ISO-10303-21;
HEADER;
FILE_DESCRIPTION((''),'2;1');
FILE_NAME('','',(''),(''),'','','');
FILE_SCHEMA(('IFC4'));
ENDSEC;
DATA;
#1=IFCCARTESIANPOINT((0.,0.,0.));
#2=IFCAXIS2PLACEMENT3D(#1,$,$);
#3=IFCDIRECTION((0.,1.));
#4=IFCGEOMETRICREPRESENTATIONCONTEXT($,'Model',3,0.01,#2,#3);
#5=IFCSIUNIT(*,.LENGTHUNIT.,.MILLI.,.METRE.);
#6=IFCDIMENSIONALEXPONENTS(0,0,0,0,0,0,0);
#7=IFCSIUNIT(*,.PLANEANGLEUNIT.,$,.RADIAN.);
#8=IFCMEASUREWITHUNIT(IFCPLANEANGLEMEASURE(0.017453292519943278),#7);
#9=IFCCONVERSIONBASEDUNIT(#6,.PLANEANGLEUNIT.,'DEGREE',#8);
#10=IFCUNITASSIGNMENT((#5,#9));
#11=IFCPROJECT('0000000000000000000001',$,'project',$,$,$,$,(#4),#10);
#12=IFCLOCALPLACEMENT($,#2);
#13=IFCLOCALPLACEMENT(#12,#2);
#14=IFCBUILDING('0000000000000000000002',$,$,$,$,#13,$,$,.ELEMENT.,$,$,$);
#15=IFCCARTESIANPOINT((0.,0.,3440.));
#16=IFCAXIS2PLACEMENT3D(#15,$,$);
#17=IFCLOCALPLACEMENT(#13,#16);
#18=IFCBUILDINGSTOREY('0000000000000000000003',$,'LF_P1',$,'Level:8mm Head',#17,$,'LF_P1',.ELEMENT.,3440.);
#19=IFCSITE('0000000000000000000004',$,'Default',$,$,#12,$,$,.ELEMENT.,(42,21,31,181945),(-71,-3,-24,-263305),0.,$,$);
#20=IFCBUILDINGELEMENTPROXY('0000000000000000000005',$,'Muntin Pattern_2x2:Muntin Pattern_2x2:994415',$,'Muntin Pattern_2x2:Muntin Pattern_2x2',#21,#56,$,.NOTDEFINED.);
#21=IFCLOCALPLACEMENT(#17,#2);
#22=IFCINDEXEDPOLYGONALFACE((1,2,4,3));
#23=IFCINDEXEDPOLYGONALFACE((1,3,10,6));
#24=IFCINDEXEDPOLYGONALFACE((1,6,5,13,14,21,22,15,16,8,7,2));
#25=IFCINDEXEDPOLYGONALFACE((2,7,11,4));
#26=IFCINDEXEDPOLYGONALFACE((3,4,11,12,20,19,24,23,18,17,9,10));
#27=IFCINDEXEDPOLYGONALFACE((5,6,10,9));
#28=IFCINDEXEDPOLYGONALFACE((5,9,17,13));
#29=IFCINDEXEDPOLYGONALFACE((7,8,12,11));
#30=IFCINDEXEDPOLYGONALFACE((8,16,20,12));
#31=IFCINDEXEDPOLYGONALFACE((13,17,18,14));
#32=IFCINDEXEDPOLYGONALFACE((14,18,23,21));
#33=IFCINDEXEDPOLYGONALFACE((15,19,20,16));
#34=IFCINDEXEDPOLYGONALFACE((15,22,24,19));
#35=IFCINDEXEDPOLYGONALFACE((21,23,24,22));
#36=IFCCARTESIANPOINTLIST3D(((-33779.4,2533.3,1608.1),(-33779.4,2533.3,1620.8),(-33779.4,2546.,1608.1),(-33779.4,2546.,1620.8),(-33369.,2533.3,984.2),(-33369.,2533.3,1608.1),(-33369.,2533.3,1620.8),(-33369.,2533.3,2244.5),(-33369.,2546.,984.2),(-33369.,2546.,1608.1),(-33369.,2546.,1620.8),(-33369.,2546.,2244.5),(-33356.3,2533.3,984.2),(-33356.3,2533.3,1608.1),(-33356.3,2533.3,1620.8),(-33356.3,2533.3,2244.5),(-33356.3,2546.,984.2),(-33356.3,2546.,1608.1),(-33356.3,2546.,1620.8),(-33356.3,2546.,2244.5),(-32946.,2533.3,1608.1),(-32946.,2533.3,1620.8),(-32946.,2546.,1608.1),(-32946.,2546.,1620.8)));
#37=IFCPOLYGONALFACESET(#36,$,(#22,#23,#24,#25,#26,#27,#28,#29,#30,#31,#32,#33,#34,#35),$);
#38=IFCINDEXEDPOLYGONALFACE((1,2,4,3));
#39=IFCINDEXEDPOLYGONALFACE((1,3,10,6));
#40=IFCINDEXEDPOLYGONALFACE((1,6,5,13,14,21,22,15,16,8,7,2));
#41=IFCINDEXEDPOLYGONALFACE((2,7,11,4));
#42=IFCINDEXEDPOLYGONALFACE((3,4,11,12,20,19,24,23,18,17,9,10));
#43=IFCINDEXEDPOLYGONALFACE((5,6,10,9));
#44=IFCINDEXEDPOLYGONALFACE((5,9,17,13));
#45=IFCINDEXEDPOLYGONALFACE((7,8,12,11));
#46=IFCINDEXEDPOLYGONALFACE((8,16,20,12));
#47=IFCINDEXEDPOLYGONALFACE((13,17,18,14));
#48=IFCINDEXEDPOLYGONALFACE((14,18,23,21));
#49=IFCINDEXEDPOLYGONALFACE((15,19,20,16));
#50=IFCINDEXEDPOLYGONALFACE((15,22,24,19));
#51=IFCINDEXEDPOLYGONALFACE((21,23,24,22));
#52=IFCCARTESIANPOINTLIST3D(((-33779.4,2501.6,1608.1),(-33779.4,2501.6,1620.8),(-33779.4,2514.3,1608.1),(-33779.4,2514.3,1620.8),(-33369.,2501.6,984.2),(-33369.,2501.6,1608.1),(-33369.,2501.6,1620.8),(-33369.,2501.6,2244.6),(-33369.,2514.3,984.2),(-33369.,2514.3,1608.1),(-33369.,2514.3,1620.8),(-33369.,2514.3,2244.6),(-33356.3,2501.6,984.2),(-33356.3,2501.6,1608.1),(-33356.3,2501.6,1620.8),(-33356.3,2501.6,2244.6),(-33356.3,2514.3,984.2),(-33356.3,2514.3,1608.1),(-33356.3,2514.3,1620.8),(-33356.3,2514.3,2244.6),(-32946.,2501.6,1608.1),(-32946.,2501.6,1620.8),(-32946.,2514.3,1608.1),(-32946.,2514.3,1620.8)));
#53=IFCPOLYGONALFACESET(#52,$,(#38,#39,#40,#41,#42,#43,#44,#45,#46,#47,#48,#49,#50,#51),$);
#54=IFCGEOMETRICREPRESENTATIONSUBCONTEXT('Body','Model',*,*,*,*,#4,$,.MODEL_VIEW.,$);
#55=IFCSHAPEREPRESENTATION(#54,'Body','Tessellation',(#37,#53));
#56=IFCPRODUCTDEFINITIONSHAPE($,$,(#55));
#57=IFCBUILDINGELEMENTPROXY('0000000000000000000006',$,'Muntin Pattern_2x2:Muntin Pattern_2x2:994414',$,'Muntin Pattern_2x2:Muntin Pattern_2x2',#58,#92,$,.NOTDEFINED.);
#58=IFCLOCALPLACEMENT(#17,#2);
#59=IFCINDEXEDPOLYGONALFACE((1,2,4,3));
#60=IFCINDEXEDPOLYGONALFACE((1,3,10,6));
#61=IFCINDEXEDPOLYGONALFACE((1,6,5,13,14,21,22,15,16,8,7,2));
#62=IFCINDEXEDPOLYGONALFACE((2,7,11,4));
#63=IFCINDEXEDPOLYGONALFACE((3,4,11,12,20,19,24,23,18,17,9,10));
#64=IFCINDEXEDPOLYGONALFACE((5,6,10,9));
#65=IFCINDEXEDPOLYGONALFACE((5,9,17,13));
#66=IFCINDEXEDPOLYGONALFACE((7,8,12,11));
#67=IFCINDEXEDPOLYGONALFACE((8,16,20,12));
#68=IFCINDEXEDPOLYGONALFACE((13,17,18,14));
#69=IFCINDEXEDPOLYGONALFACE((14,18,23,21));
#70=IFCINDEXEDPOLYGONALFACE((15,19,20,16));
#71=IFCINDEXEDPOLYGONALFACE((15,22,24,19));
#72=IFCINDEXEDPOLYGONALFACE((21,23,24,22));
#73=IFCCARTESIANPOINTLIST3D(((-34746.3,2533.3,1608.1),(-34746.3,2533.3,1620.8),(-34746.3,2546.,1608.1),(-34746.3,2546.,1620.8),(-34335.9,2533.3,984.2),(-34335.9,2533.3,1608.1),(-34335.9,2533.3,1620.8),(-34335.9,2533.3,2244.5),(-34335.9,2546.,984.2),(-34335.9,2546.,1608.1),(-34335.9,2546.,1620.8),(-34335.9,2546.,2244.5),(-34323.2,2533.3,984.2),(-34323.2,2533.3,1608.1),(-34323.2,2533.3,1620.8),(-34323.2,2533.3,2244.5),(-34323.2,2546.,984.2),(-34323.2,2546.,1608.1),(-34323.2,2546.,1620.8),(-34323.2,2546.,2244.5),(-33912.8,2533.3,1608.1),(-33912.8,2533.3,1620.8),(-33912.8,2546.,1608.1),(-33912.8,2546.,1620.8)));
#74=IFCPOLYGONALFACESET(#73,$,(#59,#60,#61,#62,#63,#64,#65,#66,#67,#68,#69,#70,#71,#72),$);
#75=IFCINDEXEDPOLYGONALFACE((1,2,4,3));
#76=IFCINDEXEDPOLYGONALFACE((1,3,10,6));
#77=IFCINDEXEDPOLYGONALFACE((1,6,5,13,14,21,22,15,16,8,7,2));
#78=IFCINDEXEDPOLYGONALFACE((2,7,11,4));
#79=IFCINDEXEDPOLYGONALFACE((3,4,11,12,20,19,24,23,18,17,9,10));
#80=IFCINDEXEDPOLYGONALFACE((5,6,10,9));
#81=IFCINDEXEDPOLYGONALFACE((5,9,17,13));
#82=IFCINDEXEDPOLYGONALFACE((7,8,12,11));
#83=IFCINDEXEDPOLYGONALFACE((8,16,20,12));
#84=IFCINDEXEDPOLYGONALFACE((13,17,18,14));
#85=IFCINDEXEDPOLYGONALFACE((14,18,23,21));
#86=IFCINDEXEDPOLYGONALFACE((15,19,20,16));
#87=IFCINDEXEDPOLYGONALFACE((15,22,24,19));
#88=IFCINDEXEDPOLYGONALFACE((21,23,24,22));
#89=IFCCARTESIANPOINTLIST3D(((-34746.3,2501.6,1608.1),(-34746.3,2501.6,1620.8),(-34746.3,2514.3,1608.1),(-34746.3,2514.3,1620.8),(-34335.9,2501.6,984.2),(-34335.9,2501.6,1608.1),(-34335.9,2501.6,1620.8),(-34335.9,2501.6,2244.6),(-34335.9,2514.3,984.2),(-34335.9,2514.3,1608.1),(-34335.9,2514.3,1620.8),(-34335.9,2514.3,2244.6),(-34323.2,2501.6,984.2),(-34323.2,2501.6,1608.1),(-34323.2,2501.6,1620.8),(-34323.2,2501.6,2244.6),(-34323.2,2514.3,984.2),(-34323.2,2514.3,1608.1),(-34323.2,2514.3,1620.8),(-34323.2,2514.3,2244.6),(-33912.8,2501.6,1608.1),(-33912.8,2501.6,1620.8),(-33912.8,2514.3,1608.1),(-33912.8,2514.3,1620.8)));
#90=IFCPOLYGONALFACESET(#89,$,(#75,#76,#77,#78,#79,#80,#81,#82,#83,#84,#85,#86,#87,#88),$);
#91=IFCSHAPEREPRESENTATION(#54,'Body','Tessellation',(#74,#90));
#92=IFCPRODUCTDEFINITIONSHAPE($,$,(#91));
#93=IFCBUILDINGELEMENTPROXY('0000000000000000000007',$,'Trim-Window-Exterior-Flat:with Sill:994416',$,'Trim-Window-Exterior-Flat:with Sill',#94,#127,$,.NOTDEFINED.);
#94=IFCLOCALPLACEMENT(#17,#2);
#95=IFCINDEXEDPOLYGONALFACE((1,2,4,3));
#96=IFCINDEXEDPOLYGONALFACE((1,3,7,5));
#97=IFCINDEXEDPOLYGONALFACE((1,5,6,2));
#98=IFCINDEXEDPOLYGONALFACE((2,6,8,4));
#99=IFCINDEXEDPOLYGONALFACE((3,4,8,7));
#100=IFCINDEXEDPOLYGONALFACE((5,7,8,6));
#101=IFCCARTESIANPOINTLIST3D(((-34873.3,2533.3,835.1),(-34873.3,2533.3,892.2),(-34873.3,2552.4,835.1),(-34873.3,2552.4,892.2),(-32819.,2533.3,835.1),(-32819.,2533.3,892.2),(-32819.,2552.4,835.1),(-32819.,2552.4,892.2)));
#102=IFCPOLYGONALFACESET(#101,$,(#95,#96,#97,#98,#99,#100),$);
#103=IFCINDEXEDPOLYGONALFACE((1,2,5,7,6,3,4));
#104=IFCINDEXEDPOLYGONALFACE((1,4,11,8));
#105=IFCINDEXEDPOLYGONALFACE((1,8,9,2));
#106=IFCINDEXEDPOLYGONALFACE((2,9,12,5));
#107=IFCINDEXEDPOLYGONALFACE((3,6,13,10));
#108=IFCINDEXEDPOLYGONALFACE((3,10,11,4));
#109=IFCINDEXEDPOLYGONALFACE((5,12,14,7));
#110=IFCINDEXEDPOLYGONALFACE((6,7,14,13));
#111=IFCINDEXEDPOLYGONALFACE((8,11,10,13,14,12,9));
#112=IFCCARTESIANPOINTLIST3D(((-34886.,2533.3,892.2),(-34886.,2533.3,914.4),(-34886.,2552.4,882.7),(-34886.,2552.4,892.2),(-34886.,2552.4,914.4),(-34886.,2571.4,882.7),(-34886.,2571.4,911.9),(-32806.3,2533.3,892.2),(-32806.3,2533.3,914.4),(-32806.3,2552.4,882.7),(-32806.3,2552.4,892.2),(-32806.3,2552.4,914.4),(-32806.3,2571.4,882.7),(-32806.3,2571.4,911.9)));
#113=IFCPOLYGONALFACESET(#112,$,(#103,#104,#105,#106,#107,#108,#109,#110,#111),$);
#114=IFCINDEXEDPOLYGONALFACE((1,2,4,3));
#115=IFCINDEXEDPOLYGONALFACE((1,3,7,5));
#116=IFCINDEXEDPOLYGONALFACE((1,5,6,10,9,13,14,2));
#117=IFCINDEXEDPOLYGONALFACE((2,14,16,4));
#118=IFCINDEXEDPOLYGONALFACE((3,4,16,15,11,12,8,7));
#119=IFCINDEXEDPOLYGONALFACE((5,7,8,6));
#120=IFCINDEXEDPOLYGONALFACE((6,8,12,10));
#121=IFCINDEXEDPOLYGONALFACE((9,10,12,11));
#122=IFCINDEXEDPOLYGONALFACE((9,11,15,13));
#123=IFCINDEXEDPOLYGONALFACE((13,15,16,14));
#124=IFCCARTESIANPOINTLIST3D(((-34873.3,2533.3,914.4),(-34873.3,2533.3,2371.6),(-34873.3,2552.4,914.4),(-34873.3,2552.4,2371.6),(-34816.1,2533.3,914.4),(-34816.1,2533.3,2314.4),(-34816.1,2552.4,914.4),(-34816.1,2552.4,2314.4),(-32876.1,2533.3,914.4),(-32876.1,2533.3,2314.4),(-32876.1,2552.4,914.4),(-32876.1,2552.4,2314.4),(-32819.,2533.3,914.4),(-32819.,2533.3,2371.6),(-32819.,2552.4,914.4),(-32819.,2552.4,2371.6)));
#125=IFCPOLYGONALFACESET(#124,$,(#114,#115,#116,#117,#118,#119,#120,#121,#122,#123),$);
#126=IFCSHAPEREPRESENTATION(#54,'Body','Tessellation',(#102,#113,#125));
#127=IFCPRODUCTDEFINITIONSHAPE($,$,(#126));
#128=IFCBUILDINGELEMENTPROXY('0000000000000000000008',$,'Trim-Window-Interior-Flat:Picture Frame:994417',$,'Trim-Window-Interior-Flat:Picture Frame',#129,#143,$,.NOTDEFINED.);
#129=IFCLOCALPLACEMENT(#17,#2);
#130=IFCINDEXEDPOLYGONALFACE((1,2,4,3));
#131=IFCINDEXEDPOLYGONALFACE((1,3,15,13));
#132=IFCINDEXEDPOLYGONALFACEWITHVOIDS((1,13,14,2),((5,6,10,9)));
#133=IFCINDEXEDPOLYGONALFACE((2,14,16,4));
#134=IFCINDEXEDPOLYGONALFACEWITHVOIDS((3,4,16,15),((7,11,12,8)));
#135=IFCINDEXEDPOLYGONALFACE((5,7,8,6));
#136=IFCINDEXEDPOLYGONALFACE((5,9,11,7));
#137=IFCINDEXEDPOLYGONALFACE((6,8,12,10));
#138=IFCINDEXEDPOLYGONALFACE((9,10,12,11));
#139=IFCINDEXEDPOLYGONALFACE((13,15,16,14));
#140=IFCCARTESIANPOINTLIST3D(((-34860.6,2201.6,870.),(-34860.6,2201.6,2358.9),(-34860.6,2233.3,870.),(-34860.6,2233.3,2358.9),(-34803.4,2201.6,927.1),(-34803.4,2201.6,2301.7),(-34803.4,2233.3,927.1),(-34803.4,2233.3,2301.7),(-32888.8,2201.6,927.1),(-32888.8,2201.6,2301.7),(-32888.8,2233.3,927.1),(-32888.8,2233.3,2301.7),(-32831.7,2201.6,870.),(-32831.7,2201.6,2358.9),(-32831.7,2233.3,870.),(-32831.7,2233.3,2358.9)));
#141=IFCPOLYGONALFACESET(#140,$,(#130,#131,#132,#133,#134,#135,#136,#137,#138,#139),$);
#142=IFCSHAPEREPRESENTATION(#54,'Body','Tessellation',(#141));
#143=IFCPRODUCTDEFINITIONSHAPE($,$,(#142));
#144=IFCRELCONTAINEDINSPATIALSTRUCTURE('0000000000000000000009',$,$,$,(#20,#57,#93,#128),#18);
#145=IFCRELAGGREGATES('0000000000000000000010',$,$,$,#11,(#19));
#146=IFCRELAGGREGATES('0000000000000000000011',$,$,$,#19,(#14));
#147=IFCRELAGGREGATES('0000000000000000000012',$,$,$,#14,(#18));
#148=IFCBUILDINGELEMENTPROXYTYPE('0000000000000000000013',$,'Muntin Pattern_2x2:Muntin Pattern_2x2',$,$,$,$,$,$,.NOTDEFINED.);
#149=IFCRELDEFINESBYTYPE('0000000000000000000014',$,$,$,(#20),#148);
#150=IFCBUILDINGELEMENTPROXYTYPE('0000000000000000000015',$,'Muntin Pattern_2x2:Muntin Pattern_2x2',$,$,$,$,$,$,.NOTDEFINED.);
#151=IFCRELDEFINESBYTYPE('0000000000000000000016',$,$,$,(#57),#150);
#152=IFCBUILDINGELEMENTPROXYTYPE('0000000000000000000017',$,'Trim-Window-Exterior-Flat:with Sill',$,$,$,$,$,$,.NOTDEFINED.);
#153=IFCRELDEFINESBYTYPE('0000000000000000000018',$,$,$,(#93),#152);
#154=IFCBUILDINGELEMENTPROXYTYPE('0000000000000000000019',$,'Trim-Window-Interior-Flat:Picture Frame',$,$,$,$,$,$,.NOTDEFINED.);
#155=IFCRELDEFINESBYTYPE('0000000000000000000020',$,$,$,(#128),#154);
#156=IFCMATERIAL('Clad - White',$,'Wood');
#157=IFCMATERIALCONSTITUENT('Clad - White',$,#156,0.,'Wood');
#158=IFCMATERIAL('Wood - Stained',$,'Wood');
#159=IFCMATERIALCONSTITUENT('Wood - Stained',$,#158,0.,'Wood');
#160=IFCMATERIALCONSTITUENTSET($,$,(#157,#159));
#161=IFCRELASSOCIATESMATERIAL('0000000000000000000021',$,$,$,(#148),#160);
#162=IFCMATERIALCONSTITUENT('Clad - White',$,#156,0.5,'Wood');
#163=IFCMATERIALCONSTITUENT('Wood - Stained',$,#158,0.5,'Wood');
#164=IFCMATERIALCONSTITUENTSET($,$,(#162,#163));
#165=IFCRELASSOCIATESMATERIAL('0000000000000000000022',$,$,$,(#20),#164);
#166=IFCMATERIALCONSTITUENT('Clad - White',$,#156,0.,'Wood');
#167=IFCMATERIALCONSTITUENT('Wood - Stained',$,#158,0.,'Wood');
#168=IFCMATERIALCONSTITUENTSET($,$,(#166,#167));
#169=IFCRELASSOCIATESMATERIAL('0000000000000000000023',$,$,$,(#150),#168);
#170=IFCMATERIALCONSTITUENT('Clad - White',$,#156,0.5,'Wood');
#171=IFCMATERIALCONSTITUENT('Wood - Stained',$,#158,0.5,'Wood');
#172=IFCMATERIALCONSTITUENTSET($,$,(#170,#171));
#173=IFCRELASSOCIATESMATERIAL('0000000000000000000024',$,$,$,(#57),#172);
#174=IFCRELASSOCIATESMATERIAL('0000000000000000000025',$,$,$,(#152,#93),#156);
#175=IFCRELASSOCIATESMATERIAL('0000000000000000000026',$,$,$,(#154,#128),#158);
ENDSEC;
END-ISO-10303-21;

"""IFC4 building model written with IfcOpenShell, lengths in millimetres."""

from ifc_helpers import new_model, entity, si_unit, converted_unit, direction, frame, origin, place, context, subcontext, project, spatial, indexed_curve, outline, extrude, source, transform, mapped, material, constituent, constituent_set, type_object, type_shapes, element, save


model = new_model("IFC4")

# Units and contexts
model_context = context("Model", 3, precision=0.01, world=origin(), true_north=direction((0.0, 1.0)))
body_context = subcontext(model_context, "Body", "Model", "MODEL_VIEW")
ifc_project = project(units=[si_unit("LENGTHUNIT", "METRE", prefix="MILLI"), converted_unit("PLANEANGLEUNIT", "DEGREE", entity("IfcPlaneAngleMeasure", 0.017453292519943278), si_unit("PLANEANGLEUNIT", "RADIAN"), dimensions=[0, 0, 0, 0, 0, 0, 0])], contexts=[model_context])

# Site, building, storey
site_placement = place(None, origin())
site = spatial("IfcSite", under=ifc_project, at=site_placement, Name="Default", CompositionType="ELEMENT", RefLatitude=(42, 21, 31, 181945), RefLongitude=(-71, -3, -24, -263305), RefElevation=0.0)
building_placement = place(site_placement, origin())
building = spatial("IfcBuilding", under=site, at=building_placement, CompositionType="ELEMENT")
storey_placement = place(building_placement, frame((0.0, 0.0, 3440.0)))
storey = spatial("IfcBuildingStorey", under=building, at=storey_placement, Name="LF_P1", ObjectType="Level:8mm Head", LongName="LF_P1", CompositionType="ELEMENT", Elevation=3440.0)

# Building element proxies
ifc_material_1 = material(Name="Clad - White", Category="Wood")
ifc_material_2 = material(Name="Wood - Stained", Category="Wood")
ifc_constituent_1 = constituent(ifc_material_1, Name="Clad - White", Category="Wood", fraction=0.5)
ifc_constituent_2 = constituent(ifc_material_2, Name="Wood - Stained", Category="Wood", fraction=0.5)
ifc_constituent_set_1 = constituent_set(constituents=[ifc_constituent_1, ifc_constituent_2])
ifc_constituent_3 = constituent(ifc_material_1, Name="Clad - White", Category="Wood", fraction=0.0)
ifc_constituent_4 = constituent(ifc_material_2, Name="Wood - Stained", Category="Wood", fraction=0.0)
ifc_constituent_set_2 = constituent_set(constituents=[ifc_constituent_3, ifc_constituent_4])
building_element_proxy_type_1 = type_object("IfcBuildingElementProxyType", Name="Muntin Pattern_2x2:Muntin Pattern_2x2", PredefinedType="NOTDEFINED", material=ifc_constituent_set_2)
shared_shape_1 = source(origin(), body_context, "Body", "SweptSolid", [
    extrude(outline(indexed_curve([(6.4, -6.4), (630.1, -6.4), (630.1, 6.3), (6.4, 6.3), (6.4, 416.7), (-6.3, 416.7), (-6.3, 6.3), (-630.2, 6.3), (-630.2, -6.4), (-6.3, -6.4), (-6.3, -416.7), (6.4, -416.7), (6.4, -6.4)], self_intersect=False)), frame((0.0, -22.2, 630.1), z_axis=(0.0, 1.0, 0.0), x_axis=(0.0, 0.0, 1.0)), (0.0, 0.0, 1.0), 12.7),
    extrude(outline(indexed_curve([(6.4, -6.4), (630.2, -6.4), (630.2, 6.3), (6.4, 6.3), (6.4, 416.7), (-6.3, 416.7), (-6.3, 6.3), (-630.2, 6.3), (-630.2, -6.4), (-6.3, -6.4), (-6.3, -416.7), (6.4, -416.7), (6.4, -6.4)], self_intersect=False)), frame((0.0, 9.5, 630.2), z_axis=(0.0, 1.0, 0.0), x_axis=(0.0, 0.0, 1.0)), (0.0, 0.0, 1.0), 12.7),
])
type_shapes(building_element_proxy_type_1, [shared_shape_1])
proxy_1_placement = place(storey_placement, frame((-33362.7, 2523.8, 984.3), z_axis=(0.0, 0.0, 1.0), x_axis=(-1.0, 0.0, 0.0)))
element("IfcBuildingElementProxy", 1, at=proxy_1_placement, inside=storey, type_object=building_element_proxy_type_1, material=ifc_constituent_set_1, Name="Muntin Pattern_2x2:Muntin Pattern_2x2:994415", ObjectType="Muntin Pattern_2x2:Muntin Pattern_2x2", PredefinedType="NOTDEFINED", context=body_context, shape_type="MappedRepresentation", body=[
    mapped(shared_shape_1, transform((0.0, 0.0, 0.0), scale=1.0)),
])
ifc_constituent_5 = constituent(ifc_material_1, Name="Clad - White", Category="Wood", fraction=0.5)
ifc_constituent_6 = constituent(ifc_material_2, Name="Wood - Stained", Category="Wood", fraction=0.5)
ifc_constituent_set_3 = constituent_set(constituents=[ifc_constituent_5, ifc_constituent_6])
ifc_constituent_7 = constituent(ifc_material_1, Name="Clad - White", Category="Wood", fraction=0.0)
ifc_constituent_8 = constituent(ifc_material_2, Name="Wood - Stained", Category="Wood", fraction=0.0)
ifc_constituent_set_4 = constituent_set(constituents=[ifc_constituent_7, ifc_constituent_8])
building_element_proxy_type_2 = type_object("IfcBuildingElementProxyType", Name="Muntin Pattern_2x2:Muntin Pattern_2x2", PredefinedType="NOTDEFINED", material=ifc_constituent_set_4)
shared_shape_2 = source(origin(), body_context, "Body", "SweptSolid", [
    extrude(outline(indexed_curve([(6.4, -6.4), (630.1, -6.4), (630.1, 6.3), (6.4, 6.3), (6.4, 416.7), (-6.3, 416.7), (-6.3, 6.3), (-630.2, 6.3), (-630.2, -6.4), (-6.3, -6.4), (-6.3, -416.7), (6.4, -416.7), (6.4, -6.4)], self_intersect=False)), frame((0.0, 9.5, 630.1), z_axis=(0.0, 1.0, 0.0), x_axis=(0.0, 0.0, 1.0)), (0.0, 0.0, 1.0), 12.7),
    extrude(outline(indexed_curve([(6.4, -6.4), (630.2, -6.4), (630.2, 6.3), (6.4, 6.3), (6.4, 416.7), (-6.3, 416.7), (-6.3, 6.3), (-630.2, 6.3), (-630.2, -6.4), (-6.3, -6.4), (-6.3, -416.7), (6.4, -416.7), (6.4, -6.4)], self_intersect=False)), frame((0.0, -22.2, 630.2), z_axis=(0.0, 1.0, 0.0), x_axis=(0.0, 0.0, 1.0)), (0.0, 0.0, 1.0), 12.7),
])
type_shapes(building_element_proxy_type_2, [shared_shape_2])
proxy_2_placement = place(storey_placement, frame((-34329.5, 2523.8, 984.3)))
element("IfcBuildingElementProxy", 2, at=proxy_2_placement, inside=storey, type_object=building_element_proxy_type_2, material=ifc_constituent_set_3, Name="Muntin Pattern_2x2:Muntin Pattern_2x2:994414", ObjectType="Muntin Pattern_2x2:Muntin Pattern_2x2", PredefinedType="NOTDEFINED", context=body_context, shape_type="MappedRepresentation", body=[
    mapped(shared_shape_2, transform((0.0, 0.0, 0.0), scale=1.0)),
])
building_element_proxy_type_3 = type_object("IfcBuildingElementProxyType", Name="Trim-Window-Exterior-Flat:with Sill", PredefinedType="NOTDEFINED", material=ifc_material_1)
shared_shape_3 = source(origin(), body_context, "Body", "SweptSolid", [
    extrude(outline(indexed_curve([(-1027.1, -28.6), (1027.1, -28.6), (1027.1, 28.6), (-1027.1, 28.6), (-1027.1, -28.6)], self_intersect=False)), frame((0.0, -1450.8, 0.0), z_axis=(0.0, 0.0, 1.0), x_axis=(-1.0, 0.0, 0.0)), (0.0, 0.0, 1.0), 19.0),
    extrude(outline(indexed_curve([(-19.0, -16.0), (0.0, -16.0), (0.0, -6.4), (19.0, -6.4), (19.0, 15.8), (0.0, 15.8), (-19.0, 13.3), (-19.0, -16.0)], self_intersect=False)), frame((-1039.8, -1415.8, 19.0), z_axis=(1.0, 0.0, 0.0), x_axis=(0.0, 0.0, -1.0)), (0.0, 0.0, 1.0), 2079.7),
    extrude(outline(indexed_curve([(-742.9, -1027.1), (714.3, -1027.1), (714.3, -970.0), (-685.7, -970.0), (-685.7, 970.0), (714.3, 970.0), (714.3, 1027.1), (-742.9, 1027.1), (-742.9, -1027.1)], self_intersect=False)), frame((0.0, -685.7, 0.0), z_axis=(0.0, 0.0, 1.0), x_axis=(0.0, -1.0, 0.0)), (0.0, 0.0, 1.0), 19.0),
])
type_shapes(building_element_proxy_type_3, [shared_shape_3])
proxy_3_placement = place(storey_placement, frame((-33846.1, 2533.3, 2314.4), z_axis=(0.0, 1.0, 0.0), x_axis=(-1.0, 0.0, 0.0)))
element("IfcBuildingElementProxy", 3, at=proxy_3_placement, inside=storey, type_object=building_element_proxy_type_3, material=ifc_material_1, Name="Trim-Window-Exterior-Flat:with Sill:994416", ObjectType="Trim-Window-Exterior-Flat:with Sill", PredefinedType="NOTDEFINED", context=body_context, shape_type="MappedRepresentation", body=[
    mapped(shared_shape_3, transform((0.0, 0.0, 0.0), scale=1.0)),
])
building_element_proxy_type_4 = type_object("IfcBuildingElementProxyType", Name="Trim-Window-Interior-Flat:Picture Frame", PredefinedType="NOTDEFINED", material=ifc_material_2)
shared_shape_4 = source(origin(), body_context, "Body", "SweptSolid", [
    extrude(outline(indexed_curve([(-1014.4, -744.4), (1014.4, -744.4), (1014.4, 744.4), (-1014.4, 744.4), (-1014.4, -744.4)], self_intersect=False), holes=[indexed_curve([(-957.3, -687.3), (-957.3, 687.3), (957.3, 687.3), (957.3, -687.3), (-957.3, -687.3)], self_intersect=False)]), frame((0.0, -700.0, 0.0), z_axis=(0.0, 0.0, 1.0), x_axis=(-1.0, 0.0, 0.0)), (0.0, 0.0, 1.0), 31.7),
])
type_shapes(building_element_proxy_type_4, [shared_shape_4])
proxy_4_placement = place(storey_placement, frame((-33846.1, 2233.3, 2314.4), z_axis=(0.0, -1.0, 0.0), x_axis=(1.0, 0.0, 0.0)))
element("IfcBuildingElementProxy", 4, at=proxy_4_placement, inside=storey, type_object=building_element_proxy_type_4, material=ifc_material_2, Name="Trim-Window-Interior-Flat:Picture Frame:994417", ObjectType="Trim-Window-Interior-Flat:Picture Frame", PredefinedType="NOTDEFINED", context=body_context, shape_type="MappedRepresentation", body=[
    mapped(shared_shape_4, transform((0.0, 0.0, 0.0), scale=1.0)),
])

save(model, "model.ifc")
